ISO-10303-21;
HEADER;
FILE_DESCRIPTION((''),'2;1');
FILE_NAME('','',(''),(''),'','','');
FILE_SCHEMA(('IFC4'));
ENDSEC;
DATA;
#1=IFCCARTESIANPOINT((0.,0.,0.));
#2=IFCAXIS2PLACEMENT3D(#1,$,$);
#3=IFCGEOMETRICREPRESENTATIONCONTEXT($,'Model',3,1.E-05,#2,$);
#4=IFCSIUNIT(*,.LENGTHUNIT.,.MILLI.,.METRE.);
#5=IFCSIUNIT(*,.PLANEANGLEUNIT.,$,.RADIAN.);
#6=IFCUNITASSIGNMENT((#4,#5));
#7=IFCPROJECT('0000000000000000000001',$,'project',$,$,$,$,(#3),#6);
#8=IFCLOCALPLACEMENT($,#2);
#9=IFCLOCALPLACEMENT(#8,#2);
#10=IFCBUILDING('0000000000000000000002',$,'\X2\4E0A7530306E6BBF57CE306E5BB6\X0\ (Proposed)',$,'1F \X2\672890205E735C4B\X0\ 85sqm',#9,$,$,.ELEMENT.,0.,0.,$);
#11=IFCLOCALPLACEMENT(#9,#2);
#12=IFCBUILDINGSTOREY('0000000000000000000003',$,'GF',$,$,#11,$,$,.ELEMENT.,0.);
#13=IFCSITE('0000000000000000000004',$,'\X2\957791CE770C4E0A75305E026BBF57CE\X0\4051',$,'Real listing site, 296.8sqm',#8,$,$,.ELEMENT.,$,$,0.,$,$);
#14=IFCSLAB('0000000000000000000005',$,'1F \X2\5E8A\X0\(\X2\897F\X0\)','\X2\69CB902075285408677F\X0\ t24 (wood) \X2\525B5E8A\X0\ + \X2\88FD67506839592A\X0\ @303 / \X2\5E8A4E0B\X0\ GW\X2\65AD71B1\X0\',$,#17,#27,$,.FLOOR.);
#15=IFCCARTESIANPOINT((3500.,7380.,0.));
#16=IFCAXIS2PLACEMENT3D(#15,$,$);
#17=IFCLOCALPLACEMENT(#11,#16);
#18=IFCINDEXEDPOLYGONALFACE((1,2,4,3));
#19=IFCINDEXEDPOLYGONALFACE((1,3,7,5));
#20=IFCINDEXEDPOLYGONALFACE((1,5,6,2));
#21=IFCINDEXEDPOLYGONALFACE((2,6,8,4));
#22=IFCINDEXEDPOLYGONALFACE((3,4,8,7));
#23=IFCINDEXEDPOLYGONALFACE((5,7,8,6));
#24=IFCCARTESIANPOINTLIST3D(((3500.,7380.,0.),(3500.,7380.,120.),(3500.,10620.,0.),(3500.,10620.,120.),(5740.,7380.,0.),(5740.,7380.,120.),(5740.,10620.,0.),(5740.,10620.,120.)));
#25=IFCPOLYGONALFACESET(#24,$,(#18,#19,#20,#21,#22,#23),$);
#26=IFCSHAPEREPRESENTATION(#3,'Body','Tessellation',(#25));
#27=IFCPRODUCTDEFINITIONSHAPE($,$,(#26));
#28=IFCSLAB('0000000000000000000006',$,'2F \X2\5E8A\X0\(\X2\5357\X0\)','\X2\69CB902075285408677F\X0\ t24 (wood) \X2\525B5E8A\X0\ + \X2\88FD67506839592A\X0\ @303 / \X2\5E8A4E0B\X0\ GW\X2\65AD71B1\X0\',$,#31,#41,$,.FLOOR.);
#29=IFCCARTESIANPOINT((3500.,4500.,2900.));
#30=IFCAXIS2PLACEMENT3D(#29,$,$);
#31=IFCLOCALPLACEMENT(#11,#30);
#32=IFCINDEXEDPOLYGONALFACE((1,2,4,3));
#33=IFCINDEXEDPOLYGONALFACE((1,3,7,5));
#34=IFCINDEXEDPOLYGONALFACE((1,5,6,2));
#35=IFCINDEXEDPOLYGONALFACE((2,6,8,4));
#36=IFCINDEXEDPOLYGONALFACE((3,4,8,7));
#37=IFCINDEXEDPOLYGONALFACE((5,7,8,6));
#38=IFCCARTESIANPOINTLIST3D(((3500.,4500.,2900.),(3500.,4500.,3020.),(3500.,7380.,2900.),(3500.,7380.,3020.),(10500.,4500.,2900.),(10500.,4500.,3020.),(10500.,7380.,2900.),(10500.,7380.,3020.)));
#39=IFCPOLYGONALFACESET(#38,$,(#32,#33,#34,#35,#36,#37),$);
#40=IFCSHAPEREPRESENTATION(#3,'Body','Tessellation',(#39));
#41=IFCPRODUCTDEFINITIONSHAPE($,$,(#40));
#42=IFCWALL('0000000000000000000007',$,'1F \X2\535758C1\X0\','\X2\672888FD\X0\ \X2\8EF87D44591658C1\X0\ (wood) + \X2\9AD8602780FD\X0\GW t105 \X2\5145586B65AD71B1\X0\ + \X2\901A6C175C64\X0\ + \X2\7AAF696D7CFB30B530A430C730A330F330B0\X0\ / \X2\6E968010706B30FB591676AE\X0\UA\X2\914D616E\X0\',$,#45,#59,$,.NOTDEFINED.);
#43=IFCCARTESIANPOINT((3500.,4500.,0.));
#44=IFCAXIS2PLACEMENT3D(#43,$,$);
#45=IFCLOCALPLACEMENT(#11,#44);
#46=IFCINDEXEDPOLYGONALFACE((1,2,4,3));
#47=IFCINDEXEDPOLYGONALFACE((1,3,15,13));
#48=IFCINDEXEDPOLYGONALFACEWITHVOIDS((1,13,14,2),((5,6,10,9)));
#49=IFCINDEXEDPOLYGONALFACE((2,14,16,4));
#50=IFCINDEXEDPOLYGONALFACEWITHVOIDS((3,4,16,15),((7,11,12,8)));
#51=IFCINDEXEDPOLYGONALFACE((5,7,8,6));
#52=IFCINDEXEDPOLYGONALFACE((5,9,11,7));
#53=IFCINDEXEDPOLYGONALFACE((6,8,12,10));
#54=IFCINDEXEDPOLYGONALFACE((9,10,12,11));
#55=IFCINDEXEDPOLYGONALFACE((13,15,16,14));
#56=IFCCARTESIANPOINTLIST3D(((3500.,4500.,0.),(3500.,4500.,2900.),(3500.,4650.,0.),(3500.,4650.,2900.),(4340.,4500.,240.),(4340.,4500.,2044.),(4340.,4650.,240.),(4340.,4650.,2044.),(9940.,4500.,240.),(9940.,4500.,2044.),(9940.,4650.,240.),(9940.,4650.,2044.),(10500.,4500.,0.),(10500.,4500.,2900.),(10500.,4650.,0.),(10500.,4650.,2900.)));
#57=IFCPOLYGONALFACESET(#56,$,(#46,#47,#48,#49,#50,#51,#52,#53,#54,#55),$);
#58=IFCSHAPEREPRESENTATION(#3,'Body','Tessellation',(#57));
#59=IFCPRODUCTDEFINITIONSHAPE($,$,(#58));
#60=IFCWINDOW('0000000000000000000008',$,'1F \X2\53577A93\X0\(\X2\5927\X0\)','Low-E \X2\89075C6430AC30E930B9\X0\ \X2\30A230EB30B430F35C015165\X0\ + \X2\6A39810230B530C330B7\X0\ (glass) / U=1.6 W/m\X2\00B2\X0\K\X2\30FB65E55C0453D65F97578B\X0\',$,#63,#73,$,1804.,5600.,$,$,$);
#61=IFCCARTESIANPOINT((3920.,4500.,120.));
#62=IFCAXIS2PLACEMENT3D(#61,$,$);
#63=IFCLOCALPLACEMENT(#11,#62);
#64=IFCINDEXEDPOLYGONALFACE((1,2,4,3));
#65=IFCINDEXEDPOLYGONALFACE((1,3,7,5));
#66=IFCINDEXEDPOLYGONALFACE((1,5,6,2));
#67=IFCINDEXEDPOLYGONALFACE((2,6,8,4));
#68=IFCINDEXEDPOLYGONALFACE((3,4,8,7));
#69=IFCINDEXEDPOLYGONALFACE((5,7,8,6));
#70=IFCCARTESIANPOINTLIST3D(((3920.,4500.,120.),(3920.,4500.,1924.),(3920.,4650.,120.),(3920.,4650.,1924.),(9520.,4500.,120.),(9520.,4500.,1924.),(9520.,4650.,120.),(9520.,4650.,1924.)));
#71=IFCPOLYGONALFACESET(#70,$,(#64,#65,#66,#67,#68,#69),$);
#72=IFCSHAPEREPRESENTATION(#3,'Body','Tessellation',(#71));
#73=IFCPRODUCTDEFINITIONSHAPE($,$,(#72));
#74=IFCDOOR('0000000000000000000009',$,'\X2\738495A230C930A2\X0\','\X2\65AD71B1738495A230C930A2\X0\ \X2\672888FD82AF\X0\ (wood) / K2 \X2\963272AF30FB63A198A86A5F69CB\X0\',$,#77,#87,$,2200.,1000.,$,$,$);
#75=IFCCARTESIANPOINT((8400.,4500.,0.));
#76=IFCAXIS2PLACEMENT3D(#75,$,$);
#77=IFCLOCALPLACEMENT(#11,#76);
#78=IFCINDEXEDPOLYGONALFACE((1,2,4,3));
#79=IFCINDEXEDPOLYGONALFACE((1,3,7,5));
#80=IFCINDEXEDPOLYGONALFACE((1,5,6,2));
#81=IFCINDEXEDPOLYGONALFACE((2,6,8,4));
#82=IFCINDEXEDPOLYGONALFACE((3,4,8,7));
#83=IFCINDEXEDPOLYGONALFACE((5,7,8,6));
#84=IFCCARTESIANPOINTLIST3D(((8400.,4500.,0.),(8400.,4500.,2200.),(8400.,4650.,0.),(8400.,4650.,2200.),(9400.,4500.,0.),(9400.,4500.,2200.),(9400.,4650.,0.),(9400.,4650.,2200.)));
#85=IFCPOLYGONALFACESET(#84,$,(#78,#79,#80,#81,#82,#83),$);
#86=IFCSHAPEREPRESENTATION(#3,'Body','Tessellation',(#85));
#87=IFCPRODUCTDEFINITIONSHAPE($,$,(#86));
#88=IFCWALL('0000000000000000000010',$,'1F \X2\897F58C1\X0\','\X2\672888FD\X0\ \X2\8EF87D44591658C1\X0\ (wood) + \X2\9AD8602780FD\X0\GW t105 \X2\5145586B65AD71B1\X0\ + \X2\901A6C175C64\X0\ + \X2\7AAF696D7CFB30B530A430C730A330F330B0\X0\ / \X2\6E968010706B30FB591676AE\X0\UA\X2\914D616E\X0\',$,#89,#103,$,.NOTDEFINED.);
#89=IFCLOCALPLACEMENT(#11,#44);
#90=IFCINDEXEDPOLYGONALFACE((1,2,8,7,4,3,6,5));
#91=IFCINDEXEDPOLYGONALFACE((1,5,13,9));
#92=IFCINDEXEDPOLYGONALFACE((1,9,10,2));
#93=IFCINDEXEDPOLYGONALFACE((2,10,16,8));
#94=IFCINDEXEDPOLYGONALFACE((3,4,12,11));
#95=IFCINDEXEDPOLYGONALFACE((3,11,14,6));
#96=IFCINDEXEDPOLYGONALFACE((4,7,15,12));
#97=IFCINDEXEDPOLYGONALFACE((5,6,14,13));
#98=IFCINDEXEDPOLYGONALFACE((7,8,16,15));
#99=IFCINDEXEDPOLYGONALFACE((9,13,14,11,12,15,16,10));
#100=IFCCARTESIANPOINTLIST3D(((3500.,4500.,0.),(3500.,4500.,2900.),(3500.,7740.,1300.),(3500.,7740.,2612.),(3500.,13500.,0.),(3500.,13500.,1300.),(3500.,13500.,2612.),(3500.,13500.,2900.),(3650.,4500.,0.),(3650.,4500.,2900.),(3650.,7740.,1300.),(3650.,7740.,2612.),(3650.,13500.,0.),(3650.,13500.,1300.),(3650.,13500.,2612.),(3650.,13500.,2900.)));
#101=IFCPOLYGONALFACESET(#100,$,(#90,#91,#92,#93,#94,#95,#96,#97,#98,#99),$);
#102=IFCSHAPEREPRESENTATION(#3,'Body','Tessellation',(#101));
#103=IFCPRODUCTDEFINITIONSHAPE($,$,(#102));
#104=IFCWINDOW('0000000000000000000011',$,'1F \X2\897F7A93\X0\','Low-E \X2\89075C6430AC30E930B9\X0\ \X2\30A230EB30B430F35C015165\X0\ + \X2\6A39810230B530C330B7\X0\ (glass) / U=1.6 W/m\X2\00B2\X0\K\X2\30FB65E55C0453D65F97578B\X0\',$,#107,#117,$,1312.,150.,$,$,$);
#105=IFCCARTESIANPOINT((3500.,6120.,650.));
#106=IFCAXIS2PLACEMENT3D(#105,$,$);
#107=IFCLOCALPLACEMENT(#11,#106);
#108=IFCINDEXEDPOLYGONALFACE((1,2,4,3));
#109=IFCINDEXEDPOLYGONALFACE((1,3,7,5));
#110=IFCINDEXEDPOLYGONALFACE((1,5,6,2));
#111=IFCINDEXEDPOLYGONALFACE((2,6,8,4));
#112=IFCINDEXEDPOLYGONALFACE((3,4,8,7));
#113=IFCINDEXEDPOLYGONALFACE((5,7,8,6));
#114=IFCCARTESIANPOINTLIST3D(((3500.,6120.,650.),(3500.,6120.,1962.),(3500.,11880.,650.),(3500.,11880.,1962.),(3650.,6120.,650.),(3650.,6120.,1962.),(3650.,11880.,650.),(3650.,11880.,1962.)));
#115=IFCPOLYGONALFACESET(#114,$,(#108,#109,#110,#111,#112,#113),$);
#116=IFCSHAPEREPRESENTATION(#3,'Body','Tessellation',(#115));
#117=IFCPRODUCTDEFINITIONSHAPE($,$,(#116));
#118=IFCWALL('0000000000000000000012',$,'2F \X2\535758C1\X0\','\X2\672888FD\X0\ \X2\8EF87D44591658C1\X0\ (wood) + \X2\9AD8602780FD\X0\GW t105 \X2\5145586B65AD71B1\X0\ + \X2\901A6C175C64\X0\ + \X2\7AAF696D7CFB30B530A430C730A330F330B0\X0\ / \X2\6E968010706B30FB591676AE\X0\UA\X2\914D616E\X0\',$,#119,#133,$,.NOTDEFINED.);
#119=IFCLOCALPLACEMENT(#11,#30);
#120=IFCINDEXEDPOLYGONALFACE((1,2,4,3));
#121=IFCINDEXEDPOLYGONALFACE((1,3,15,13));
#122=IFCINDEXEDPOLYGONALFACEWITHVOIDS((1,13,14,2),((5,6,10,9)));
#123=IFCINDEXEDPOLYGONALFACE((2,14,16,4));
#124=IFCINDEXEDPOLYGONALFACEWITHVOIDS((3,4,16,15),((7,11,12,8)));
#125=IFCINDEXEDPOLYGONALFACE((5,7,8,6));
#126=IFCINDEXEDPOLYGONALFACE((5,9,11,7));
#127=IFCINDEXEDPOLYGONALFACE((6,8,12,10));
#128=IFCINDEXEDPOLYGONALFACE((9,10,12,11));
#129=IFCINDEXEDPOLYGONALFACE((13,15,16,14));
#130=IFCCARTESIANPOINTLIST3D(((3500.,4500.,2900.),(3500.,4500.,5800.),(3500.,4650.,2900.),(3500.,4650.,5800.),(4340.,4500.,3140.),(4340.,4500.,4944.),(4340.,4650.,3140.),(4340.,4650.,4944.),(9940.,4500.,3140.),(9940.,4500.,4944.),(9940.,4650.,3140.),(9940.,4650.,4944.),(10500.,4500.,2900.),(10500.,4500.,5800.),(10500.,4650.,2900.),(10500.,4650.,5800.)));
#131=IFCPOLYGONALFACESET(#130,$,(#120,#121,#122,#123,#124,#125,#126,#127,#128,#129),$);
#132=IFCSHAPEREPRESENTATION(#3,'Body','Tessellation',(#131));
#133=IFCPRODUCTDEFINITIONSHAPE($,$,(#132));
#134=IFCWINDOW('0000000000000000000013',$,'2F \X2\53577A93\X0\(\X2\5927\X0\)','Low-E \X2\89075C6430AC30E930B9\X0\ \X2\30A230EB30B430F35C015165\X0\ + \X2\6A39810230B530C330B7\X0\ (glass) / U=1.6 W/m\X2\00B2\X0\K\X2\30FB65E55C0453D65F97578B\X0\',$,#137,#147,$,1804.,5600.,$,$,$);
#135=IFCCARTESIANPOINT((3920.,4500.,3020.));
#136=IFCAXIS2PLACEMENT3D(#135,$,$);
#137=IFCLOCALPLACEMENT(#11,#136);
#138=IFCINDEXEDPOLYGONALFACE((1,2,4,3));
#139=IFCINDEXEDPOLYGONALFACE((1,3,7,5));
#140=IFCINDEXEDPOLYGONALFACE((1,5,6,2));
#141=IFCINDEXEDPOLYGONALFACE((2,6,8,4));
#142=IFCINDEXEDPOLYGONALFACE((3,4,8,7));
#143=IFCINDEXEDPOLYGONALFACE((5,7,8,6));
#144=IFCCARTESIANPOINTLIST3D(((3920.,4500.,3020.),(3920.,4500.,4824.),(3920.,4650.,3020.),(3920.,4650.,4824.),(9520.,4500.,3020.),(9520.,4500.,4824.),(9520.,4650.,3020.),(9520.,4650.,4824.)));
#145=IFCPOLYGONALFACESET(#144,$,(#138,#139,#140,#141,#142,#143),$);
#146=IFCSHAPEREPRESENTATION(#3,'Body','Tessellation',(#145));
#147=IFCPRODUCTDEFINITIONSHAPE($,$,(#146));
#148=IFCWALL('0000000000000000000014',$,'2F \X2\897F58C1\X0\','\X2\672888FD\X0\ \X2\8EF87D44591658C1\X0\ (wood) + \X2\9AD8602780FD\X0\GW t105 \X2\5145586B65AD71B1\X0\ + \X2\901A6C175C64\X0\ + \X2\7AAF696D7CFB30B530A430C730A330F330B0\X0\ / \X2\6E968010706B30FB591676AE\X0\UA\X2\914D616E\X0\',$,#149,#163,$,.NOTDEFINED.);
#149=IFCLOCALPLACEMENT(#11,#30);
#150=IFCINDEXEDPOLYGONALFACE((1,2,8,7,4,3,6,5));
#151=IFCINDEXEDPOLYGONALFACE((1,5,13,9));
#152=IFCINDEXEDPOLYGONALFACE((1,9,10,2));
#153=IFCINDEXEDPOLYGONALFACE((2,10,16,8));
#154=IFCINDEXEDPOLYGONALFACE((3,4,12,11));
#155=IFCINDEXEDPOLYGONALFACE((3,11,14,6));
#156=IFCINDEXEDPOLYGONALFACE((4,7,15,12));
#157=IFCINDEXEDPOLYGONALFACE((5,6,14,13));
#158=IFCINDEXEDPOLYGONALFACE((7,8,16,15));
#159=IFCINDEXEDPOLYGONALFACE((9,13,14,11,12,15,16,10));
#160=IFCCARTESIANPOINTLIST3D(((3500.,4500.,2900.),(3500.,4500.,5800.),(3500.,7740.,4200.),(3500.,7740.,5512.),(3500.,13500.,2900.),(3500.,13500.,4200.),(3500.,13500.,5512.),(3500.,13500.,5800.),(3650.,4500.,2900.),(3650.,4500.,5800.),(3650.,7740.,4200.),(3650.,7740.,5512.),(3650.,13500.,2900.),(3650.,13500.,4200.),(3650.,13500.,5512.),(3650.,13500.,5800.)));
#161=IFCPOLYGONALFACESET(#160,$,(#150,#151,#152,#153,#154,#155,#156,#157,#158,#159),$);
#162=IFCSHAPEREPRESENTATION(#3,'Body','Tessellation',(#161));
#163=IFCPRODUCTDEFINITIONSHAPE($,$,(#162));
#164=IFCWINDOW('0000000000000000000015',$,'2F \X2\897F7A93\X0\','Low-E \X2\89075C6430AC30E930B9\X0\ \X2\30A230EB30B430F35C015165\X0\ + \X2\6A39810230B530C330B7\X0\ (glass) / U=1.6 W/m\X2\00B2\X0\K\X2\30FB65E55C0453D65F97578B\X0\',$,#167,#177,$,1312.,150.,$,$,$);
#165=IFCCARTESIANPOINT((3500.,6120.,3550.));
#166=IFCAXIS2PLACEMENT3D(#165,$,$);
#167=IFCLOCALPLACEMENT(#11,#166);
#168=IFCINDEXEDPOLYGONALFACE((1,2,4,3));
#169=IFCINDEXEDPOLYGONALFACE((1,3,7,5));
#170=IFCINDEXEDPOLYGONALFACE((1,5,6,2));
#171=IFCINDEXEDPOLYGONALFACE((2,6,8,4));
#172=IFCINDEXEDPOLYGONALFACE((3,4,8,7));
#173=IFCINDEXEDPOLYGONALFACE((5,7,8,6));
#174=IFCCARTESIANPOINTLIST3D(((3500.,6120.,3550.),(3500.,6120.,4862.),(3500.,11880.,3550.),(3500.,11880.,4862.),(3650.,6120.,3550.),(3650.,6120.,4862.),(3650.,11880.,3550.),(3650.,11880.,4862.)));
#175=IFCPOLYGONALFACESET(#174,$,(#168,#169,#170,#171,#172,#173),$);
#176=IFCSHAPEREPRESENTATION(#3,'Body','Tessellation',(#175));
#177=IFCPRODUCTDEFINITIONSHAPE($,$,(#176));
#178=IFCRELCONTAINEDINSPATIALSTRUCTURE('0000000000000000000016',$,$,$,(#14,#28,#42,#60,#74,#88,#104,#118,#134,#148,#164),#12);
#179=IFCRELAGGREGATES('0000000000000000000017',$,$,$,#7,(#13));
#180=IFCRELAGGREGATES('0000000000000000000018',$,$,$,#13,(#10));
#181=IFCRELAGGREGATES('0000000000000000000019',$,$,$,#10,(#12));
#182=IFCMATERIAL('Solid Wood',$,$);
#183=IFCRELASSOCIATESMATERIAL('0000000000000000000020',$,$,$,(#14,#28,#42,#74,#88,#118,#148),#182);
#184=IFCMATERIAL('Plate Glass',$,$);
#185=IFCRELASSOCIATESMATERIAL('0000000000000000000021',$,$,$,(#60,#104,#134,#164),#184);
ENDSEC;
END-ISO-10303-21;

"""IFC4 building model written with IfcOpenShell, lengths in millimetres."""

from ifc_helpers import new_model, si_unit, frame, frame_2d, origin, place, context, project, spatial, rectangle, extrude, material, element, fill, save


model = new_model("IFC4")

# Units and contexts
model_context = context("Model", 3, precision=1e-05, world=origin())
ifc_project = project(units=[si_unit("LENGTHUNIT", "METRE", prefix="MILLI"), si_unit("PLANEANGLEUNIT", "RADIAN")], contexts=[model_context])

# Site, building, storey
site_placement = place(None, origin())
site = spatial("IfcSite", under=ifc_project, at=site_placement, Name="長野県上田市殿城4051", ObjectType="Real listing site, 296.8sqm", CompositionType="ELEMENT", RefElevation=0.0)
building_placement = place(site_placement, origin())
building = spatial("IfcBuilding", under=site, at=building_placement, Name="上田の殿城の家 (Proposed)", ObjectType="1F 木造平屋 85sqm", CompositionType="ELEMENT", ElevationOfRefHeight=0.0, ElevationOfTerrain=0.0)
storey_placement = place(building_placement, origin())
storey = spatial("IfcBuildingStorey", under=building, at=storey_placement, Name="GF", CompositionType="ELEMENT", Elevation=0.0)

# Slabs
ifc_material_1 = material(Name="Solid Wood")
slab_1_placement = place(storey_placement, frame((3500.0, 7380.0, 0.0)))
element("IfcSlab", 1, at=slab_1_placement, inside=storey, material=ifc_material_1, Name="1F 床(西)", Description="構造用合板 t24 (wood) 剛床 + 製材根太 @303 / 床下 GW断熱", PredefinedType="FLOOR", context=model_context, shape_type="SweptSolid", body=[
    extrude(rectangle(XDim=2240.0, YDim=3240.0, at=frame_2d((1120.0, 1620.0))), frame((3500.0, 7380.0, 0.0)), (0.0, 0.0, 1.0), 120.0),
])
slab_2_placement = place(storey_placement, frame((3500.0, 4500.0, 2900.0)))
element("IfcSlab", 2, at=slab_2_placement, inside=storey, material=ifc_material_1, Name="2F 床(南)", Description="構造用合板 t24 (wood) 剛床 + 製材根太 @303 / 床下 GW断熱", PredefinedType="FLOOR", context=model_context, shape_type="SweptSolid", body=[
    extrude(rectangle(XDim=7000.0, YDim=2880.0, at=frame_2d((3500.0, 1440.0))), frame((3500.0, 4500.0, 2900.0)), (0.0, 0.0, 1.0), 120.0),
])

# Wall, openings, window, door
wall_1_placement = place(storey_placement, frame((3500.0, 4500.0, 0.0)))
wall_1 = element("IfcWall", 3, at=wall_1_placement, inside=storey, material=ifc_material_1, Name="1F 南壁", Description="木製 軸組外壁 (wood) + 高性能GW t105 充填断熱 + 通気層 + 窯業系サイディング / 準耐火・外皮UA配慮", PredefinedType="NOTDEFINED", context=model_context, shape_type="SweptSolid", body=[
    extrude(rectangle(XDim=7000.0, YDim=150.0, at=frame_2d((3500.0, 75.0))), frame((3500.0, 4500.0, 0.0)), (0.0, 0.0, 1.0), 2900.0),
])
opening_1_placement = place(storey_placement, frame((3920.0, 4500.0, 120.0)))
opening_1 = element("IfcOpeningElement", 4, at=opening_1_placement, cuts=wall_1, PredefinedType="NOTDEFINED", context=model_context, shape_type="SweptSolid", body=[
    extrude(rectangle(XDim=5600.0, YDim=150.0, at=frame_2d((2800.0, 75.0))), frame((3920.0, 4500.0, 120.0)), (0.0, 0.0, 1.0), 1804.0),
])
opening_2_placement = place(storey_placement, frame((8400.0, 4500.0, 0.0)))
opening_2 = element("IfcOpeningElement", 5, at=opening_2_placement, cuts=wall_1, PredefinedType="NOTDEFINED", context=model_context, shape_type="SweptSolid", body=[
    extrude(rectangle(XDim=1000.0, YDim=150.0, at=frame_2d((500.0, 75.0))), frame((8400.0, 4500.0, 0.0)), (0.0, 0.0, 1.0), 2200.0),
])
ifc_material_2 = material(Name="Plate Glass")
window_1_placement = place(storey_placement, frame((3920.0, 4500.0, 120.0)))
window_1 = element("IfcWindow", 6, at=window_1_placement, inside=storey, material=ifc_material_2, Name="1F 南窓(大)", Description="Low-E 複層ガラス アルゴン封入 + 樹脂サッシ (glass) / U=1.6 W/m²K・日射取得型", OverallHeight=1804.0, OverallWidth=5600.0, context=model_context, shape_type="SweptSolid", body=[
    extrude(rectangle(XDim=5600.0, YDim=150.0, at=frame_2d((2800.0, 75.0))), frame((3920.0, 4500.0, 120.0)), (0.0, 0.0, 1.0), 1804.0),
])
fill(opening_1, window_1)
door_placement = place(storey_placement, frame((8400.0, 4500.0, 0.0)))
door = element("IfcDoor", 7, at=door_placement, inside=storey, material=ifc_material_1, Name="玄関ドア", Description="断熱玄関ドア 木製芯 (wood) / K2 防犯・採風機構", OverallHeight=2200.0, OverallWidth=1000.0, context=model_context, shape_type="SweptSolid", body=[
    extrude(rectangle(XDim=1000.0, YDim=150.0, at=frame_2d((500.0, 75.0))), frame((8400.0, 4500.0, 0.0)), (0.0, 0.0, 1.0), 2200.0),
])
fill(opening_2, door)

# Walls, openings, windows
wall_2_placement = place(storey_placement, frame((3500.0, 4500.0, 0.0)))
wall_2 = element("IfcWall", 8, at=wall_2_placement, inside=storey, material=ifc_material_1, Name="1F 西壁", Description="木製 軸組外壁 (wood) + 高性能GW t105 充填断熱 + 通気層 + 窯業系サイディング / 準耐火・外皮UA配慮", PredefinedType="NOTDEFINED", context=model_context, shape_type="SweptSolid", body=[
    extrude(rectangle(XDim=150.0, YDim=9000.0, at=frame_2d((75.0, 4500.0))), frame((3500.0, 4500.0, 0.0)), (0.0, 0.0, 1.0), 2900.0),
])
opening_3_placement = place(storey_placement, frame((3500.0, 6120.0, 650.0)))
opening_3 = element("IfcOpeningElement", 9, at=opening_3_placement, cuts=wall_2, PredefinedType="NOTDEFINED", context=model_context, shape_type="SweptSolid", body=[
    extrude(rectangle(XDim=150.0, YDim=5760.0, at=frame_2d((75.0, 2880.0))), frame((3500.0, 6120.0, 650.0)), (0.0, 0.0, 1.0), 1312.0),
])
window_2_placement = place(storey_placement, frame((3500.0, 6120.0, 650.0)))
window_2 = element("IfcWindow", 10, at=window_2_placement, inside=storey, material=ifc_material_2, Name="1F 西窓", Description="Low-E 複層ガラス アルゴン封入 + 樹脂サッシ (glass) / U=1.6 W/m²K・日射取得型", OverallHeight=1312.0, OverallWidth=150.0, context=model_context, shape_type="SweptSolid", body=[
    extrude(rectangle(XDim=150.0, YDim=5760.0, at=frame_2d((75.0, 2880.0))), frame((3500.0, 6120.0, 650.0)), (0.0, 0.0, 1.0), 1312.0),
])
fill(opening_3, window_2)
wall_3_placement = place(storey_placement, frame((3500.0, 4500.0, 2900.0)))
wall_3 = element("IfcWall", 11, at=wall_3_placement, inside=storey, material=ifc_material_1, Name="2F 南壁", Description="木製 軸組外壁 (wood) + 高性能GW t105 充填断熱 + 通気層 + 窯業系サイディング / 準耐火・外皮UA配慮", PredefinedType="NOTDEFINED", context=model_context, shape_type="SweptSolid", body=[
    extrude(rectangle(XDim=7000.0, YDim=150.0, at=frame_2d((3500.0, 75.0))), frame((3500.0, 4500.0, 2900.0)), (0.0, 0.0, 1.0), 2900.0),
])
opening_4_placement = place(storey_placement, frame((3920.0, 4500.0, 3020.0)))
opening_4 = element("IfcOpeningElement", 12, at=opening_4_placement, cuts=wall_3, PredefinedType="NOTDEFINED", context=model_context, shape_type="SweptSolid", body=[
    extrude(rectangle(XDim=5600.0, YDim=150.0, at=frame_2d((2800.0, 75.0))), frame((3920.0, 4500.0, 3020.0)), (0.0, 0.0, 1.0), 1804.0),
])
window_3_placement = place(storey_placement, frame((3920.0, 4500.0, 3020.0)))
window_3 = element("IfcWindow", 13, at=window_3_placement, inside=storey, material=ifc_material_2, Name="2F 南窓(大)", Description="Low-E 複層ガラス アルゴン封入 + 樹脂サッシ (glass) / U=1.6 W/m²K・日射取得型", OverallHeight=1804.0, OverallWidth=5600.0, context=model_context, shape_type="SweptSolid", body=[
    extrude(rectangle(XDim=5600.0, YDim=150.0, at=frame_2d((2800.0, 75.0))), frame((3920.0, 4500.0, 3020.0)), (0.0, 0.0, 1.0), 1804.0),
])
fill(opening_4, window_3)
wall_4_placement = place(storey_placement, frame((3500.0, 4500.0, 2900.0)))
wall_4 = element("IfcWall", 14, at=wall_4_placement, inside=storey, material=ifc_material_1, Name="2F 西壁", Description="木製 軸組外壁 (wood) + 高性能GW t105 充填断熱 + 通気層 + 窯業系サイディング / 準耐火・外皮UA配慮", PredefinedType="NOTDEFINED", context=model_context, shape_type="SweptSolid", body=[
    extrude(rectangle(XDim=150.0, YDim=9000.0, at=frame_2d((75.0, 4500.0))), frame((3500.0, 4500.0, 2900.0)), (0.0, 0.0, 1.0), 2900.0),
])
opening_5_placement = place(storey_placement, frame((3500.0, 6120.0, 3550.0)))
opening_5 = element("IfcOpeningElement", 15, at=opening_5_placement, cuts=wall_4, PredefinedType="NOTDEFINED", context=model_context, shape_type="SweptSolid", body=[
    extrude(rectangle(XDim=150.0, YDim=5760.0, at=frame_2d((75.0, 2880.0))), frame((3500.0, 6120.0, 3550.0)), (0.0, 0.0, 1.0), 1312.0),
])
window_4_placement = place(storey_placement, frame((3500.0, 6120.0, 3550.0)))
window_4 = element("IfcWindow", 16, at=window_4_placement, inside=storey, material=ifc_material_2, Name="2F 西窓", Description="Low-E 複層ガラス アルゴン封入 + 樹脂サッシ (glass) / U=1.6 W/m²K・日射取得型", OverallHeight=1312.0, OverallWidth=150.0, context=model_context, shape_type="SweptSolid", body=[
    extrude(rectangle(XDim=150.0, YDim=5760.0, at=frame_2d((75.0, 2880.0))), frame((3500.0, 6120.0, 3550.0)), (0.0, 0.0, 1.0), 1312.0),
])
fill(opening_5, window_4)

save(model, "model.ifc")
